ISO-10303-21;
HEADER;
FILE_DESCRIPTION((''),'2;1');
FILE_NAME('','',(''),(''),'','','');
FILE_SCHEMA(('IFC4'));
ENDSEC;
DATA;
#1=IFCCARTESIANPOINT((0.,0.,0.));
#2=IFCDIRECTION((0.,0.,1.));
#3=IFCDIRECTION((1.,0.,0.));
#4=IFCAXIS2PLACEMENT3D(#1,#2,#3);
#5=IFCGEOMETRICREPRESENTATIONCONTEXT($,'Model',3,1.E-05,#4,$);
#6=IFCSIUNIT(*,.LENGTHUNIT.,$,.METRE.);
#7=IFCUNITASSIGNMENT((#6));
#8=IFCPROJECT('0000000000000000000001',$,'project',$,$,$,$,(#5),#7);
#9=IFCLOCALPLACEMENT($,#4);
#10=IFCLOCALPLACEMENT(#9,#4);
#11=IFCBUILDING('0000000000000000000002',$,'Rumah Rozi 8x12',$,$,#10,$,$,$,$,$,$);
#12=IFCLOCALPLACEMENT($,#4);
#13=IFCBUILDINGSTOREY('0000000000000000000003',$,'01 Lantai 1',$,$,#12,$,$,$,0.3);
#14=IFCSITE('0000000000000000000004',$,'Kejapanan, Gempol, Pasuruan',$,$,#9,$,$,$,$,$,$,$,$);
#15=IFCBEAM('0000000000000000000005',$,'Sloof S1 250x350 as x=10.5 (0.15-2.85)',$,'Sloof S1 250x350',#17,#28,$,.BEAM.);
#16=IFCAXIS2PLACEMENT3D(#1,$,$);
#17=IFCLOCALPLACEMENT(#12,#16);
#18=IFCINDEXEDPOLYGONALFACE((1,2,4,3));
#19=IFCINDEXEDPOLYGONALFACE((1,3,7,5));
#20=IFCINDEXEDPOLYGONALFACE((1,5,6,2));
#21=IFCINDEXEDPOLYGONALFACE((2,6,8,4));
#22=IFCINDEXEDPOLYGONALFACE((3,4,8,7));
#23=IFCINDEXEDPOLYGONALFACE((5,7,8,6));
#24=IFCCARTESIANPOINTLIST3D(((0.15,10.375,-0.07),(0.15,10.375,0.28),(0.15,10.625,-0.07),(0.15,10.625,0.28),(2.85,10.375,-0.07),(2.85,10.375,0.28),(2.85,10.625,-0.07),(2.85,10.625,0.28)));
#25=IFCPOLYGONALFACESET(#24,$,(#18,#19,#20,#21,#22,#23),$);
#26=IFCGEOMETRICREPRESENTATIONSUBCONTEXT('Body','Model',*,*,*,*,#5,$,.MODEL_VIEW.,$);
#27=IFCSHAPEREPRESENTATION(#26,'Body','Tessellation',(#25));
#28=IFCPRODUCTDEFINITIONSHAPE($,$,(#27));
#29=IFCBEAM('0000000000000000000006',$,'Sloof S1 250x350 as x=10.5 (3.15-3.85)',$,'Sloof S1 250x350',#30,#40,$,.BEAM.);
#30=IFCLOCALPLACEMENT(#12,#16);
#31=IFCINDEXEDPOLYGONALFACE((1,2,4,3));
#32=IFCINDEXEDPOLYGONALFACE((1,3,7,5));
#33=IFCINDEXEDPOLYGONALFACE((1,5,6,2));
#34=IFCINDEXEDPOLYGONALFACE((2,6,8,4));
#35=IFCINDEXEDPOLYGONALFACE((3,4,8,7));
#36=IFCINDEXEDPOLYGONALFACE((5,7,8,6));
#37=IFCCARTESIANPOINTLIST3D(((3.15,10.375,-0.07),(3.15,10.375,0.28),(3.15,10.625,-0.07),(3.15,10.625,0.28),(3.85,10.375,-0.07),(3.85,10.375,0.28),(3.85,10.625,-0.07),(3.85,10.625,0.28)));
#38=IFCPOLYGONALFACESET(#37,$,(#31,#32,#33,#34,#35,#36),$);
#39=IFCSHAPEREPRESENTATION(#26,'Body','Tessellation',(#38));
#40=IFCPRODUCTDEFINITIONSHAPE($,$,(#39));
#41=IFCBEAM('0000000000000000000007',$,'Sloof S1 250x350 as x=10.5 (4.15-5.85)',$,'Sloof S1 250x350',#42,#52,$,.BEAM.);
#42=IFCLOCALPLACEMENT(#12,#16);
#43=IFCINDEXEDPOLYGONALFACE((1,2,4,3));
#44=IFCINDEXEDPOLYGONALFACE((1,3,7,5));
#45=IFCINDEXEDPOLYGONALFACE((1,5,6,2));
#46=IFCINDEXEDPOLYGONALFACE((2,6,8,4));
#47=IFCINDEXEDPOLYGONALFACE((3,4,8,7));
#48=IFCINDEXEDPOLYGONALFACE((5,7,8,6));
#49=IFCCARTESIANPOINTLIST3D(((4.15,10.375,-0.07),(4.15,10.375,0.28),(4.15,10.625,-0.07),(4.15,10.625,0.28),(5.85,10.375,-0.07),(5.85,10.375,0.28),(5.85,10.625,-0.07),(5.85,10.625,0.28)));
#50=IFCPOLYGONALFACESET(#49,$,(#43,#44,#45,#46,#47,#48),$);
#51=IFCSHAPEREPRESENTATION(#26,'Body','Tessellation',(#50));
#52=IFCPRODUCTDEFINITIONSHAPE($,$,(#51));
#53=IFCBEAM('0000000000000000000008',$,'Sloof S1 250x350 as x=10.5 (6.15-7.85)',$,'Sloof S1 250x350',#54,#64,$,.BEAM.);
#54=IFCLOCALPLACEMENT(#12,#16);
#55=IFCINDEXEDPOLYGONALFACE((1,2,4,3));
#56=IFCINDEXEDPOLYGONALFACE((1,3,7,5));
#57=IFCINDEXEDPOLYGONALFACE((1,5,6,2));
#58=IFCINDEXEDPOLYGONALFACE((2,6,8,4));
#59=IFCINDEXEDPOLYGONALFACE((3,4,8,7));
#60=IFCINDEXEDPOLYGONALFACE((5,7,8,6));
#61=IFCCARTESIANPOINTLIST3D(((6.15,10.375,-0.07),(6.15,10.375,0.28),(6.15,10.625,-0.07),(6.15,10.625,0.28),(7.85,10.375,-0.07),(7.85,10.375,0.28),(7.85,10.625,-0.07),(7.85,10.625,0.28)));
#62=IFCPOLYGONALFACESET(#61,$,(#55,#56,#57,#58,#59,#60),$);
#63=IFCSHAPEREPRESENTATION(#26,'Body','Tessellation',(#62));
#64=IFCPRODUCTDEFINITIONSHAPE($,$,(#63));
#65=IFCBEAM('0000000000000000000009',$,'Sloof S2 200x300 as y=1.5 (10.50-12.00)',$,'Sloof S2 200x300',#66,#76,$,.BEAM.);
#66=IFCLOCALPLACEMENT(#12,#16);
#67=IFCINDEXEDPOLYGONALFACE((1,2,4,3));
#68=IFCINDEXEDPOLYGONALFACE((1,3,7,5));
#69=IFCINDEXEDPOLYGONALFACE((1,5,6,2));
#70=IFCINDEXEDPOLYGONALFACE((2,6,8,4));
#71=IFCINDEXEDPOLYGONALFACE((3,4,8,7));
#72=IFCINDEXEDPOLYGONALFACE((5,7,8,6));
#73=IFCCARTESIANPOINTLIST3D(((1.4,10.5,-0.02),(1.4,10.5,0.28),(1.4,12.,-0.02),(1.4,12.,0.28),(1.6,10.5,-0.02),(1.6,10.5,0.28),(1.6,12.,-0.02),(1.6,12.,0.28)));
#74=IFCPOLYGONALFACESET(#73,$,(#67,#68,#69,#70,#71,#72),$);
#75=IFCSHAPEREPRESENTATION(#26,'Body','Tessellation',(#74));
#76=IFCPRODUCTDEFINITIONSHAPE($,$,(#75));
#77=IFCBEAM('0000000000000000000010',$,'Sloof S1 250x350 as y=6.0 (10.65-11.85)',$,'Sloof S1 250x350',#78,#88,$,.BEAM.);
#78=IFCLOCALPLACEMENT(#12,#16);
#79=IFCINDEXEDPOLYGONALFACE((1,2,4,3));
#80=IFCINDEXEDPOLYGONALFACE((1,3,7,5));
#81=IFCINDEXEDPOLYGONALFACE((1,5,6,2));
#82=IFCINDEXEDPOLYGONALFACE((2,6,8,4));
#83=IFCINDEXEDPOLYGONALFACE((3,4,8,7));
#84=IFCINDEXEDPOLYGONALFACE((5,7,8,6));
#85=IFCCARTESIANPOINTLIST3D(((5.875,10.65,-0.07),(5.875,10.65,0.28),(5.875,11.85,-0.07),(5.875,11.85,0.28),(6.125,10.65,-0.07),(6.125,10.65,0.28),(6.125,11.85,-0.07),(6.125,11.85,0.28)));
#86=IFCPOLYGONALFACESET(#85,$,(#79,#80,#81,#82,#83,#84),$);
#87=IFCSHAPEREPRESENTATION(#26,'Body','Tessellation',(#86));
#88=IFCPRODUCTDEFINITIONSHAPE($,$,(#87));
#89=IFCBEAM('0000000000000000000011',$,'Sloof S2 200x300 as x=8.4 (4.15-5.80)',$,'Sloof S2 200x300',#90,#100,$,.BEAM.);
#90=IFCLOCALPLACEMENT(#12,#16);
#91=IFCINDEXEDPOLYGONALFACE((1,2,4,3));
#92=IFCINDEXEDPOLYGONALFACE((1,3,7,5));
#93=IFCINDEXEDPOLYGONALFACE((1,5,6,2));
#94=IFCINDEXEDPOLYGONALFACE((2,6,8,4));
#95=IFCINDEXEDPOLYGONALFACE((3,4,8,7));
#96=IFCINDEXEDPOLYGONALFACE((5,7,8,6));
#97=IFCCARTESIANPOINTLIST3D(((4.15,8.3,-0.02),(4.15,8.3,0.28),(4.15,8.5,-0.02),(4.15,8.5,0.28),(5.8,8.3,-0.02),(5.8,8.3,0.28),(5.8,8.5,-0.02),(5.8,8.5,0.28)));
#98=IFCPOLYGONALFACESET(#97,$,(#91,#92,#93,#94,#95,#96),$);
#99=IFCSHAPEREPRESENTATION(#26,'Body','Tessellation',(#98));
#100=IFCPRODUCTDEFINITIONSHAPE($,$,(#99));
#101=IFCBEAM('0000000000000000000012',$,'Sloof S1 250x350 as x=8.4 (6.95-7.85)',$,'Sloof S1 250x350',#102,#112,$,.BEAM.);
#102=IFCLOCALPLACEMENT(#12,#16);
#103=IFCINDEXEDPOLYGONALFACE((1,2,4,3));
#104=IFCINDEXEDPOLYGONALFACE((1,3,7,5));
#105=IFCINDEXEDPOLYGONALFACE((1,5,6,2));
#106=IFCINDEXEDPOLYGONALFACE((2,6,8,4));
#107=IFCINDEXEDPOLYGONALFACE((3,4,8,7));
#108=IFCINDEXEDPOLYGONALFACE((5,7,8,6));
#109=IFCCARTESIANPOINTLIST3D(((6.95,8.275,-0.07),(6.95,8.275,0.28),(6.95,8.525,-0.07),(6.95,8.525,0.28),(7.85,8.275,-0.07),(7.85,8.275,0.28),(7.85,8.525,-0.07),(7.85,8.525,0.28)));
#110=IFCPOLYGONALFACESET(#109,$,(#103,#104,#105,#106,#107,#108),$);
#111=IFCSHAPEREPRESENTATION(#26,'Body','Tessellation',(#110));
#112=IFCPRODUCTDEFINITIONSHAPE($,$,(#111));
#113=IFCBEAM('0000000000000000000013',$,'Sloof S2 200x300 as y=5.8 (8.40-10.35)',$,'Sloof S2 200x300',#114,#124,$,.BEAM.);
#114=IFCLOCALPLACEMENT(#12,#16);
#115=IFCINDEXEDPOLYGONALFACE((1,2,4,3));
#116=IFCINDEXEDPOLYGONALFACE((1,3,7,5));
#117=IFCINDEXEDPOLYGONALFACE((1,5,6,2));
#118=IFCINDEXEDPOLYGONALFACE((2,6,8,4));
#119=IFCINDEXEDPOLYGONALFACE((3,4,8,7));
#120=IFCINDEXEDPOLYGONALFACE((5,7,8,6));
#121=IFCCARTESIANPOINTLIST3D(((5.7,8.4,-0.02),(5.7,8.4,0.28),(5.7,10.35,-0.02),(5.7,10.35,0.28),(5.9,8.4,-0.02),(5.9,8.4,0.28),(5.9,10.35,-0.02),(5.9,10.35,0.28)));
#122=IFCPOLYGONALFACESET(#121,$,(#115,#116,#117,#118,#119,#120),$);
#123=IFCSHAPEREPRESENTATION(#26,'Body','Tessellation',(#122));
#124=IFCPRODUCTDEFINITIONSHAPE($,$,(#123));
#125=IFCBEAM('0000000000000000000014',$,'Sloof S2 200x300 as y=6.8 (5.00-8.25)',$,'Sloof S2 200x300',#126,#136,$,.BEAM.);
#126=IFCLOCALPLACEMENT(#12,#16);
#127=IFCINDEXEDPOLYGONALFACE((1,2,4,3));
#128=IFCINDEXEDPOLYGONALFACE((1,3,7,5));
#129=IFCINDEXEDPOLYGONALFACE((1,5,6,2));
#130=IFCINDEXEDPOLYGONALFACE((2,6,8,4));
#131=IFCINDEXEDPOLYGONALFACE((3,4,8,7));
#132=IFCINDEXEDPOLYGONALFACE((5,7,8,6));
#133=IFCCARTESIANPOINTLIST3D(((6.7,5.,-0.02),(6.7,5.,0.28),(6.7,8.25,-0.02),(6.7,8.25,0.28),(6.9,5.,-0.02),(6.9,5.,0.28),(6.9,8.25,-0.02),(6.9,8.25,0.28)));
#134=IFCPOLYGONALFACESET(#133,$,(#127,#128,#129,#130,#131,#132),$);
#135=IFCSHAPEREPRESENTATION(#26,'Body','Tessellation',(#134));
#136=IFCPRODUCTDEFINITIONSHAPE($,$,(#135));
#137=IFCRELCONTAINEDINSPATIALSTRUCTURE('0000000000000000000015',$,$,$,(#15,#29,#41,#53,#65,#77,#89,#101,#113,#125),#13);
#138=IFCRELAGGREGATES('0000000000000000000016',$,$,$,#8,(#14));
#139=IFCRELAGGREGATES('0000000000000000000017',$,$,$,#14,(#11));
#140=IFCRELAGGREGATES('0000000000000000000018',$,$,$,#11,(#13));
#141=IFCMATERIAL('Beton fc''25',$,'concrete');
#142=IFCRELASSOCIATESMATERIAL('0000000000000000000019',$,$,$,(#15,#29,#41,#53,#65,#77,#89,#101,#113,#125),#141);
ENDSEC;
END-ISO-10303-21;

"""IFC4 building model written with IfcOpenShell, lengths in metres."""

from ifc_helpers import new_model, si_unit, frame, origin_with_axes, place, context, subcontext, project, spatial, line, indexed_curve, outline, extrude, material, element, save


model = new_model("IFC4")

# Units and contexts
model_context = context("Model", 3, precision=1e-05, world=origin_with_axes())
body_context = subcontext(model_context, "Body", "Model", "MODEL_VIEW")
ifc_project = project(units=[si_unit("LENGTHUNIT", "METRE")], contexts=[model_context])

# Site, building, storey
site_placement = place(None, origin_with_axes())
site = spatial("IfcSite", under=ifc_project, at=site_placement, Name="Kejapanan, Gempol, Pasuruan")
building_placement = place(site_placement, origin_with_axes())
building = spatial("IfcBuilding", under=site, at=building_placement, Name="Rumah Rozi 8x12")
storey_placement = place(None, origin_with_axes())
storey = spatial("IfcBuildingStorey", under=building, at=storey_placement, Name="01 Lantai 1", Elevation=0.3)

# Shared definitions
ifc_material = material(Name="Beton fc'25", Category="concrete")

# Beams
beam_1_placement = place(storey_placement, origin_with_axes())
element("IfcBeam", 1, at=beam_1_placement, inside=storey, material=ifc_material, Name="Sloof S1 250x350 as x=10.5 (0.15-2.85)", ObjectType="Sloof S1 250x350", PredefinedType="BEAM", context=body_context, shape_type="SweptSolid", body=[
    extrude(outline(indexed_curve([(0.15, 10.375), (2.85, 10.375), (2.85, 10.625), (0.15, 10.625)], segments=[line(1, 2, 3, 4, 1)])), frame((0.0, 0.0, -0.07), z_axis=(0.0, 0.0, 1.0), x_axis=(1.0, 0.0, 0.0)), (0.0, 0.0, 1.0), 0.35),
])
beam_2_placement = place(storey_placement, origin_with_axes())
element("IfcBeam", 2, at=beam_2_placement, inside=storey, material=ifc_material, Name="Sloof S1 250x350 as x=10.5 (3.15-3.85)", ObjectType="Sloof S1 250x350", PredefinedType="BEAM", context=body_context, shape_type="SweptSolid", body=[
    extrude(outline(indexed_curve([(3.15, 10.375), (3.85, 10.375), (3.85, 10.625), (3.15, 10.625)], segments=[line(1, 2, 3, 4, 1)])), frame((0.0, 0.0, -0.07), z_axis=(0.0, 0.0, 1.0), x_axis=(1.0, 0.0, 0.0)), (0.0, 0.0, 1.0), 0.35),
])
beam_3_placement = place(storey_placement, origin_with_axes())
element("IfcBeam", 3, at=beam_3_placement, inside=storey, material=ifc_material, Name="Sloof S1 250x350 as x=10.5 (4.15-5.85)", ObjectType="Sloof S1 250x350", PredefinedType="BEAM", context=body_context, shape_type="SweptSolid", body=[
    extrude(outline(indexed_curve([(4.15, 10.375), (5.85, 10.375), (5.85, 10.625), (4.15, 10.625)], segments=[line(1, 2, 3, 4, 1)])), frame((0.0, 0.0, -0.07), z_axis=(0.0, 0.0, 1.0), x_axis=(1.0, 0.0, 0.0)), (0.0, 0.0, 1.0), 0.35),
])
beam_4_placement = place(storey_placement, origin_with_axes())
element("IfcBeam", 4, at=beam_4_placement, inside=storey, material=ifc_material, Name="Sloof S1 250x350 as x=10.5 (6.15-7.85)", ObjectType="Sloof S1 250x350", PredefinedType="BEAM", context=body_context, shape_type="SweptSolid", body=[
    extrude(outline(indexed_curve([(6.15, 10.375), (7.85, 10.375), (7.85, 10.625), (6.15, 10.625)], segments=[line(1, 2, 3, 4, 1)])), frame((0.0, 0.0, -0.07), z_axis=(0.0, 0.0, 1.0), x_axis=(1.0, 0.0, 0.0)), (0.0, 0.0, 1.0), 0.35),
])
beam_5_placement = place(storey_placement, origin_with_axes())
element("IfcBeam", 5, at=beam_5_placement, inside=storey, material=ifc_material, Name="Sloof S2 200x300 as y=1.5 (10.50-12.00)", ObjectType="Sloof S2 200x300", PredefinedType="BEAM", context=body_context, shape_type="SweptSolid", body=[
    extrude(outline(indexed_curve([(1.4, 10.5), (1.6, 10.5), (1.6, 12.0), (1.4, 12.0)], segments=[line(1, 2, 3, 4, 1)])), frame((0.0, 0.0, -0.02), z_axis=(0.0, 0.0, 1.0), x_axis=(1.0, 0.0, 0.0)), (0.0, 0.0, 1.0), 0.3),
])
beam_6_placement = place(storey_placement, origin_with_axes())
element("IfcBeam", 6, at=beam_6_placement, inside=storey, material=ifc_material, Name="Sloof S1 250x350 as y=6.0 (10.65-11.85)", ObjectType="Sloof S1 250x350", PredefinedType="BEAM", context=body_context, shape_type="SweptSolid", body=[
    extrude(outline(indexed_curve([(5.875, 10.65), (6.125, 10.65), (6.125, 11.85), (5.875, 11.85)], segments=[line(1, 2, 3, 4, 1)])), frame((0.0, 0.0, -0.07), z_axis=(0.0, 0.0, 1.0), x_axis=(1.0, 0.0, 0.0)), (0.0, 0.0, 1.0), 0.35),
])
beam_7_placement = place(storey_placement, origin_with_axes())
element("IfcBeam", 7, at=beam_7_placement, inside=storey, material=ifc_material, Name="Sloof S2 200x300 as x=8.4 (4.15-5.80)", ObjectType="Sloof S2 200x300", PredefinedType="BEAM", context=body_context, shape_type="SweptSolid", body=[
    extrude(outline(indexed_curve([(4.15, 8.3), (5.8, 8.3), (5.8, 8.5), (4.15, 8.5)], segments=[line(1, 2, 3, 4, 1)])), frame((0.0, 0.0, -0.02), z_axis=(0.0, 0.0, 1.0), x_axis=(1.0, 0.0, 0.0)), (0.0, 0.0, 1.0), 0.3),
])
beam_8_placement = place(storey_placement, origin_with_axes())
element("IfcBeam", 8, at=beam_8_placement, inside=storey, material=ifc_material, Name="Sloof S1 250x350 as x=8.4 (6.95-7.85)", ObjectType="Sloof S1 250x350", PredefinedType="BEAM", context=body_context, shape_type="SweptSolid", body=[
    extrude(outline(indexed_curve([(6.95, 8.275), (7.85, 8.275), (7.85, 8.525), (6.95, 8.525)], segments=[line(1, 2, 3, 4, 1)])), frame((0.0, 0.0, -0.07), z_axis=(0.0, 0.0, 1.0), x_axis=(1.0, 0.0, 0.0)), (0.0, 0.0, 1.0), 0.35),
])
beam_9_placement = place(storey_placement, origin_with_axes())
element("IfcBeam", 9, at=beam_9_placement, inside=storey, material=ifc_material, Name="Sloof S2 200x300 as y=5.8 (8.40-10.35)", ObjectType="Sloof S2 200x300", PredefinedType="BEAM", context=body_context, shape_type="SweptSolid", body=[
    extrude(outline(indexed_curve([(5.7, 8.4), (5.9, 8.4), (5.9, 10.35), (5.7, 10.35)], segments=[line(1, 2, 3, 4, 1)])), frame((0.0, 0.0, -0.02), z_axis=(0.0, 0.0, 1.0), x_axis=(1.0, 0.0, 0.0)), (0.0, 0.0, 1.0), 0.3),
])
beam_10_placement = place(storey_placement, origin_with_axes())
element("IfcBeam", 10, at=beam_10_placement, inside=storey, material=ifc_material, Name="Sloof S2 200x300 as y=6.8 (5.00-8.25)", ObjectType="Sloof S2 200x300", PredefinedType="BEAM", context=body_context, shape_type="SweptSolid", body=[
    extrude(outline(indexed_curve([(6.7, 5.0), (6.9, 5.0), (6.9, 8.25), (6.7, 8.25)], segments=[line(1, 2, 3, 4, 1)])), frame((0.0, 0.0, -0.02), z_axis=(0.0, 0.0, 1.0), x_axis=(1.0, 0.0, 0.0)), (0.0, 0.0, 1.0), 0.3),
])

save(model, "model.ifc")
